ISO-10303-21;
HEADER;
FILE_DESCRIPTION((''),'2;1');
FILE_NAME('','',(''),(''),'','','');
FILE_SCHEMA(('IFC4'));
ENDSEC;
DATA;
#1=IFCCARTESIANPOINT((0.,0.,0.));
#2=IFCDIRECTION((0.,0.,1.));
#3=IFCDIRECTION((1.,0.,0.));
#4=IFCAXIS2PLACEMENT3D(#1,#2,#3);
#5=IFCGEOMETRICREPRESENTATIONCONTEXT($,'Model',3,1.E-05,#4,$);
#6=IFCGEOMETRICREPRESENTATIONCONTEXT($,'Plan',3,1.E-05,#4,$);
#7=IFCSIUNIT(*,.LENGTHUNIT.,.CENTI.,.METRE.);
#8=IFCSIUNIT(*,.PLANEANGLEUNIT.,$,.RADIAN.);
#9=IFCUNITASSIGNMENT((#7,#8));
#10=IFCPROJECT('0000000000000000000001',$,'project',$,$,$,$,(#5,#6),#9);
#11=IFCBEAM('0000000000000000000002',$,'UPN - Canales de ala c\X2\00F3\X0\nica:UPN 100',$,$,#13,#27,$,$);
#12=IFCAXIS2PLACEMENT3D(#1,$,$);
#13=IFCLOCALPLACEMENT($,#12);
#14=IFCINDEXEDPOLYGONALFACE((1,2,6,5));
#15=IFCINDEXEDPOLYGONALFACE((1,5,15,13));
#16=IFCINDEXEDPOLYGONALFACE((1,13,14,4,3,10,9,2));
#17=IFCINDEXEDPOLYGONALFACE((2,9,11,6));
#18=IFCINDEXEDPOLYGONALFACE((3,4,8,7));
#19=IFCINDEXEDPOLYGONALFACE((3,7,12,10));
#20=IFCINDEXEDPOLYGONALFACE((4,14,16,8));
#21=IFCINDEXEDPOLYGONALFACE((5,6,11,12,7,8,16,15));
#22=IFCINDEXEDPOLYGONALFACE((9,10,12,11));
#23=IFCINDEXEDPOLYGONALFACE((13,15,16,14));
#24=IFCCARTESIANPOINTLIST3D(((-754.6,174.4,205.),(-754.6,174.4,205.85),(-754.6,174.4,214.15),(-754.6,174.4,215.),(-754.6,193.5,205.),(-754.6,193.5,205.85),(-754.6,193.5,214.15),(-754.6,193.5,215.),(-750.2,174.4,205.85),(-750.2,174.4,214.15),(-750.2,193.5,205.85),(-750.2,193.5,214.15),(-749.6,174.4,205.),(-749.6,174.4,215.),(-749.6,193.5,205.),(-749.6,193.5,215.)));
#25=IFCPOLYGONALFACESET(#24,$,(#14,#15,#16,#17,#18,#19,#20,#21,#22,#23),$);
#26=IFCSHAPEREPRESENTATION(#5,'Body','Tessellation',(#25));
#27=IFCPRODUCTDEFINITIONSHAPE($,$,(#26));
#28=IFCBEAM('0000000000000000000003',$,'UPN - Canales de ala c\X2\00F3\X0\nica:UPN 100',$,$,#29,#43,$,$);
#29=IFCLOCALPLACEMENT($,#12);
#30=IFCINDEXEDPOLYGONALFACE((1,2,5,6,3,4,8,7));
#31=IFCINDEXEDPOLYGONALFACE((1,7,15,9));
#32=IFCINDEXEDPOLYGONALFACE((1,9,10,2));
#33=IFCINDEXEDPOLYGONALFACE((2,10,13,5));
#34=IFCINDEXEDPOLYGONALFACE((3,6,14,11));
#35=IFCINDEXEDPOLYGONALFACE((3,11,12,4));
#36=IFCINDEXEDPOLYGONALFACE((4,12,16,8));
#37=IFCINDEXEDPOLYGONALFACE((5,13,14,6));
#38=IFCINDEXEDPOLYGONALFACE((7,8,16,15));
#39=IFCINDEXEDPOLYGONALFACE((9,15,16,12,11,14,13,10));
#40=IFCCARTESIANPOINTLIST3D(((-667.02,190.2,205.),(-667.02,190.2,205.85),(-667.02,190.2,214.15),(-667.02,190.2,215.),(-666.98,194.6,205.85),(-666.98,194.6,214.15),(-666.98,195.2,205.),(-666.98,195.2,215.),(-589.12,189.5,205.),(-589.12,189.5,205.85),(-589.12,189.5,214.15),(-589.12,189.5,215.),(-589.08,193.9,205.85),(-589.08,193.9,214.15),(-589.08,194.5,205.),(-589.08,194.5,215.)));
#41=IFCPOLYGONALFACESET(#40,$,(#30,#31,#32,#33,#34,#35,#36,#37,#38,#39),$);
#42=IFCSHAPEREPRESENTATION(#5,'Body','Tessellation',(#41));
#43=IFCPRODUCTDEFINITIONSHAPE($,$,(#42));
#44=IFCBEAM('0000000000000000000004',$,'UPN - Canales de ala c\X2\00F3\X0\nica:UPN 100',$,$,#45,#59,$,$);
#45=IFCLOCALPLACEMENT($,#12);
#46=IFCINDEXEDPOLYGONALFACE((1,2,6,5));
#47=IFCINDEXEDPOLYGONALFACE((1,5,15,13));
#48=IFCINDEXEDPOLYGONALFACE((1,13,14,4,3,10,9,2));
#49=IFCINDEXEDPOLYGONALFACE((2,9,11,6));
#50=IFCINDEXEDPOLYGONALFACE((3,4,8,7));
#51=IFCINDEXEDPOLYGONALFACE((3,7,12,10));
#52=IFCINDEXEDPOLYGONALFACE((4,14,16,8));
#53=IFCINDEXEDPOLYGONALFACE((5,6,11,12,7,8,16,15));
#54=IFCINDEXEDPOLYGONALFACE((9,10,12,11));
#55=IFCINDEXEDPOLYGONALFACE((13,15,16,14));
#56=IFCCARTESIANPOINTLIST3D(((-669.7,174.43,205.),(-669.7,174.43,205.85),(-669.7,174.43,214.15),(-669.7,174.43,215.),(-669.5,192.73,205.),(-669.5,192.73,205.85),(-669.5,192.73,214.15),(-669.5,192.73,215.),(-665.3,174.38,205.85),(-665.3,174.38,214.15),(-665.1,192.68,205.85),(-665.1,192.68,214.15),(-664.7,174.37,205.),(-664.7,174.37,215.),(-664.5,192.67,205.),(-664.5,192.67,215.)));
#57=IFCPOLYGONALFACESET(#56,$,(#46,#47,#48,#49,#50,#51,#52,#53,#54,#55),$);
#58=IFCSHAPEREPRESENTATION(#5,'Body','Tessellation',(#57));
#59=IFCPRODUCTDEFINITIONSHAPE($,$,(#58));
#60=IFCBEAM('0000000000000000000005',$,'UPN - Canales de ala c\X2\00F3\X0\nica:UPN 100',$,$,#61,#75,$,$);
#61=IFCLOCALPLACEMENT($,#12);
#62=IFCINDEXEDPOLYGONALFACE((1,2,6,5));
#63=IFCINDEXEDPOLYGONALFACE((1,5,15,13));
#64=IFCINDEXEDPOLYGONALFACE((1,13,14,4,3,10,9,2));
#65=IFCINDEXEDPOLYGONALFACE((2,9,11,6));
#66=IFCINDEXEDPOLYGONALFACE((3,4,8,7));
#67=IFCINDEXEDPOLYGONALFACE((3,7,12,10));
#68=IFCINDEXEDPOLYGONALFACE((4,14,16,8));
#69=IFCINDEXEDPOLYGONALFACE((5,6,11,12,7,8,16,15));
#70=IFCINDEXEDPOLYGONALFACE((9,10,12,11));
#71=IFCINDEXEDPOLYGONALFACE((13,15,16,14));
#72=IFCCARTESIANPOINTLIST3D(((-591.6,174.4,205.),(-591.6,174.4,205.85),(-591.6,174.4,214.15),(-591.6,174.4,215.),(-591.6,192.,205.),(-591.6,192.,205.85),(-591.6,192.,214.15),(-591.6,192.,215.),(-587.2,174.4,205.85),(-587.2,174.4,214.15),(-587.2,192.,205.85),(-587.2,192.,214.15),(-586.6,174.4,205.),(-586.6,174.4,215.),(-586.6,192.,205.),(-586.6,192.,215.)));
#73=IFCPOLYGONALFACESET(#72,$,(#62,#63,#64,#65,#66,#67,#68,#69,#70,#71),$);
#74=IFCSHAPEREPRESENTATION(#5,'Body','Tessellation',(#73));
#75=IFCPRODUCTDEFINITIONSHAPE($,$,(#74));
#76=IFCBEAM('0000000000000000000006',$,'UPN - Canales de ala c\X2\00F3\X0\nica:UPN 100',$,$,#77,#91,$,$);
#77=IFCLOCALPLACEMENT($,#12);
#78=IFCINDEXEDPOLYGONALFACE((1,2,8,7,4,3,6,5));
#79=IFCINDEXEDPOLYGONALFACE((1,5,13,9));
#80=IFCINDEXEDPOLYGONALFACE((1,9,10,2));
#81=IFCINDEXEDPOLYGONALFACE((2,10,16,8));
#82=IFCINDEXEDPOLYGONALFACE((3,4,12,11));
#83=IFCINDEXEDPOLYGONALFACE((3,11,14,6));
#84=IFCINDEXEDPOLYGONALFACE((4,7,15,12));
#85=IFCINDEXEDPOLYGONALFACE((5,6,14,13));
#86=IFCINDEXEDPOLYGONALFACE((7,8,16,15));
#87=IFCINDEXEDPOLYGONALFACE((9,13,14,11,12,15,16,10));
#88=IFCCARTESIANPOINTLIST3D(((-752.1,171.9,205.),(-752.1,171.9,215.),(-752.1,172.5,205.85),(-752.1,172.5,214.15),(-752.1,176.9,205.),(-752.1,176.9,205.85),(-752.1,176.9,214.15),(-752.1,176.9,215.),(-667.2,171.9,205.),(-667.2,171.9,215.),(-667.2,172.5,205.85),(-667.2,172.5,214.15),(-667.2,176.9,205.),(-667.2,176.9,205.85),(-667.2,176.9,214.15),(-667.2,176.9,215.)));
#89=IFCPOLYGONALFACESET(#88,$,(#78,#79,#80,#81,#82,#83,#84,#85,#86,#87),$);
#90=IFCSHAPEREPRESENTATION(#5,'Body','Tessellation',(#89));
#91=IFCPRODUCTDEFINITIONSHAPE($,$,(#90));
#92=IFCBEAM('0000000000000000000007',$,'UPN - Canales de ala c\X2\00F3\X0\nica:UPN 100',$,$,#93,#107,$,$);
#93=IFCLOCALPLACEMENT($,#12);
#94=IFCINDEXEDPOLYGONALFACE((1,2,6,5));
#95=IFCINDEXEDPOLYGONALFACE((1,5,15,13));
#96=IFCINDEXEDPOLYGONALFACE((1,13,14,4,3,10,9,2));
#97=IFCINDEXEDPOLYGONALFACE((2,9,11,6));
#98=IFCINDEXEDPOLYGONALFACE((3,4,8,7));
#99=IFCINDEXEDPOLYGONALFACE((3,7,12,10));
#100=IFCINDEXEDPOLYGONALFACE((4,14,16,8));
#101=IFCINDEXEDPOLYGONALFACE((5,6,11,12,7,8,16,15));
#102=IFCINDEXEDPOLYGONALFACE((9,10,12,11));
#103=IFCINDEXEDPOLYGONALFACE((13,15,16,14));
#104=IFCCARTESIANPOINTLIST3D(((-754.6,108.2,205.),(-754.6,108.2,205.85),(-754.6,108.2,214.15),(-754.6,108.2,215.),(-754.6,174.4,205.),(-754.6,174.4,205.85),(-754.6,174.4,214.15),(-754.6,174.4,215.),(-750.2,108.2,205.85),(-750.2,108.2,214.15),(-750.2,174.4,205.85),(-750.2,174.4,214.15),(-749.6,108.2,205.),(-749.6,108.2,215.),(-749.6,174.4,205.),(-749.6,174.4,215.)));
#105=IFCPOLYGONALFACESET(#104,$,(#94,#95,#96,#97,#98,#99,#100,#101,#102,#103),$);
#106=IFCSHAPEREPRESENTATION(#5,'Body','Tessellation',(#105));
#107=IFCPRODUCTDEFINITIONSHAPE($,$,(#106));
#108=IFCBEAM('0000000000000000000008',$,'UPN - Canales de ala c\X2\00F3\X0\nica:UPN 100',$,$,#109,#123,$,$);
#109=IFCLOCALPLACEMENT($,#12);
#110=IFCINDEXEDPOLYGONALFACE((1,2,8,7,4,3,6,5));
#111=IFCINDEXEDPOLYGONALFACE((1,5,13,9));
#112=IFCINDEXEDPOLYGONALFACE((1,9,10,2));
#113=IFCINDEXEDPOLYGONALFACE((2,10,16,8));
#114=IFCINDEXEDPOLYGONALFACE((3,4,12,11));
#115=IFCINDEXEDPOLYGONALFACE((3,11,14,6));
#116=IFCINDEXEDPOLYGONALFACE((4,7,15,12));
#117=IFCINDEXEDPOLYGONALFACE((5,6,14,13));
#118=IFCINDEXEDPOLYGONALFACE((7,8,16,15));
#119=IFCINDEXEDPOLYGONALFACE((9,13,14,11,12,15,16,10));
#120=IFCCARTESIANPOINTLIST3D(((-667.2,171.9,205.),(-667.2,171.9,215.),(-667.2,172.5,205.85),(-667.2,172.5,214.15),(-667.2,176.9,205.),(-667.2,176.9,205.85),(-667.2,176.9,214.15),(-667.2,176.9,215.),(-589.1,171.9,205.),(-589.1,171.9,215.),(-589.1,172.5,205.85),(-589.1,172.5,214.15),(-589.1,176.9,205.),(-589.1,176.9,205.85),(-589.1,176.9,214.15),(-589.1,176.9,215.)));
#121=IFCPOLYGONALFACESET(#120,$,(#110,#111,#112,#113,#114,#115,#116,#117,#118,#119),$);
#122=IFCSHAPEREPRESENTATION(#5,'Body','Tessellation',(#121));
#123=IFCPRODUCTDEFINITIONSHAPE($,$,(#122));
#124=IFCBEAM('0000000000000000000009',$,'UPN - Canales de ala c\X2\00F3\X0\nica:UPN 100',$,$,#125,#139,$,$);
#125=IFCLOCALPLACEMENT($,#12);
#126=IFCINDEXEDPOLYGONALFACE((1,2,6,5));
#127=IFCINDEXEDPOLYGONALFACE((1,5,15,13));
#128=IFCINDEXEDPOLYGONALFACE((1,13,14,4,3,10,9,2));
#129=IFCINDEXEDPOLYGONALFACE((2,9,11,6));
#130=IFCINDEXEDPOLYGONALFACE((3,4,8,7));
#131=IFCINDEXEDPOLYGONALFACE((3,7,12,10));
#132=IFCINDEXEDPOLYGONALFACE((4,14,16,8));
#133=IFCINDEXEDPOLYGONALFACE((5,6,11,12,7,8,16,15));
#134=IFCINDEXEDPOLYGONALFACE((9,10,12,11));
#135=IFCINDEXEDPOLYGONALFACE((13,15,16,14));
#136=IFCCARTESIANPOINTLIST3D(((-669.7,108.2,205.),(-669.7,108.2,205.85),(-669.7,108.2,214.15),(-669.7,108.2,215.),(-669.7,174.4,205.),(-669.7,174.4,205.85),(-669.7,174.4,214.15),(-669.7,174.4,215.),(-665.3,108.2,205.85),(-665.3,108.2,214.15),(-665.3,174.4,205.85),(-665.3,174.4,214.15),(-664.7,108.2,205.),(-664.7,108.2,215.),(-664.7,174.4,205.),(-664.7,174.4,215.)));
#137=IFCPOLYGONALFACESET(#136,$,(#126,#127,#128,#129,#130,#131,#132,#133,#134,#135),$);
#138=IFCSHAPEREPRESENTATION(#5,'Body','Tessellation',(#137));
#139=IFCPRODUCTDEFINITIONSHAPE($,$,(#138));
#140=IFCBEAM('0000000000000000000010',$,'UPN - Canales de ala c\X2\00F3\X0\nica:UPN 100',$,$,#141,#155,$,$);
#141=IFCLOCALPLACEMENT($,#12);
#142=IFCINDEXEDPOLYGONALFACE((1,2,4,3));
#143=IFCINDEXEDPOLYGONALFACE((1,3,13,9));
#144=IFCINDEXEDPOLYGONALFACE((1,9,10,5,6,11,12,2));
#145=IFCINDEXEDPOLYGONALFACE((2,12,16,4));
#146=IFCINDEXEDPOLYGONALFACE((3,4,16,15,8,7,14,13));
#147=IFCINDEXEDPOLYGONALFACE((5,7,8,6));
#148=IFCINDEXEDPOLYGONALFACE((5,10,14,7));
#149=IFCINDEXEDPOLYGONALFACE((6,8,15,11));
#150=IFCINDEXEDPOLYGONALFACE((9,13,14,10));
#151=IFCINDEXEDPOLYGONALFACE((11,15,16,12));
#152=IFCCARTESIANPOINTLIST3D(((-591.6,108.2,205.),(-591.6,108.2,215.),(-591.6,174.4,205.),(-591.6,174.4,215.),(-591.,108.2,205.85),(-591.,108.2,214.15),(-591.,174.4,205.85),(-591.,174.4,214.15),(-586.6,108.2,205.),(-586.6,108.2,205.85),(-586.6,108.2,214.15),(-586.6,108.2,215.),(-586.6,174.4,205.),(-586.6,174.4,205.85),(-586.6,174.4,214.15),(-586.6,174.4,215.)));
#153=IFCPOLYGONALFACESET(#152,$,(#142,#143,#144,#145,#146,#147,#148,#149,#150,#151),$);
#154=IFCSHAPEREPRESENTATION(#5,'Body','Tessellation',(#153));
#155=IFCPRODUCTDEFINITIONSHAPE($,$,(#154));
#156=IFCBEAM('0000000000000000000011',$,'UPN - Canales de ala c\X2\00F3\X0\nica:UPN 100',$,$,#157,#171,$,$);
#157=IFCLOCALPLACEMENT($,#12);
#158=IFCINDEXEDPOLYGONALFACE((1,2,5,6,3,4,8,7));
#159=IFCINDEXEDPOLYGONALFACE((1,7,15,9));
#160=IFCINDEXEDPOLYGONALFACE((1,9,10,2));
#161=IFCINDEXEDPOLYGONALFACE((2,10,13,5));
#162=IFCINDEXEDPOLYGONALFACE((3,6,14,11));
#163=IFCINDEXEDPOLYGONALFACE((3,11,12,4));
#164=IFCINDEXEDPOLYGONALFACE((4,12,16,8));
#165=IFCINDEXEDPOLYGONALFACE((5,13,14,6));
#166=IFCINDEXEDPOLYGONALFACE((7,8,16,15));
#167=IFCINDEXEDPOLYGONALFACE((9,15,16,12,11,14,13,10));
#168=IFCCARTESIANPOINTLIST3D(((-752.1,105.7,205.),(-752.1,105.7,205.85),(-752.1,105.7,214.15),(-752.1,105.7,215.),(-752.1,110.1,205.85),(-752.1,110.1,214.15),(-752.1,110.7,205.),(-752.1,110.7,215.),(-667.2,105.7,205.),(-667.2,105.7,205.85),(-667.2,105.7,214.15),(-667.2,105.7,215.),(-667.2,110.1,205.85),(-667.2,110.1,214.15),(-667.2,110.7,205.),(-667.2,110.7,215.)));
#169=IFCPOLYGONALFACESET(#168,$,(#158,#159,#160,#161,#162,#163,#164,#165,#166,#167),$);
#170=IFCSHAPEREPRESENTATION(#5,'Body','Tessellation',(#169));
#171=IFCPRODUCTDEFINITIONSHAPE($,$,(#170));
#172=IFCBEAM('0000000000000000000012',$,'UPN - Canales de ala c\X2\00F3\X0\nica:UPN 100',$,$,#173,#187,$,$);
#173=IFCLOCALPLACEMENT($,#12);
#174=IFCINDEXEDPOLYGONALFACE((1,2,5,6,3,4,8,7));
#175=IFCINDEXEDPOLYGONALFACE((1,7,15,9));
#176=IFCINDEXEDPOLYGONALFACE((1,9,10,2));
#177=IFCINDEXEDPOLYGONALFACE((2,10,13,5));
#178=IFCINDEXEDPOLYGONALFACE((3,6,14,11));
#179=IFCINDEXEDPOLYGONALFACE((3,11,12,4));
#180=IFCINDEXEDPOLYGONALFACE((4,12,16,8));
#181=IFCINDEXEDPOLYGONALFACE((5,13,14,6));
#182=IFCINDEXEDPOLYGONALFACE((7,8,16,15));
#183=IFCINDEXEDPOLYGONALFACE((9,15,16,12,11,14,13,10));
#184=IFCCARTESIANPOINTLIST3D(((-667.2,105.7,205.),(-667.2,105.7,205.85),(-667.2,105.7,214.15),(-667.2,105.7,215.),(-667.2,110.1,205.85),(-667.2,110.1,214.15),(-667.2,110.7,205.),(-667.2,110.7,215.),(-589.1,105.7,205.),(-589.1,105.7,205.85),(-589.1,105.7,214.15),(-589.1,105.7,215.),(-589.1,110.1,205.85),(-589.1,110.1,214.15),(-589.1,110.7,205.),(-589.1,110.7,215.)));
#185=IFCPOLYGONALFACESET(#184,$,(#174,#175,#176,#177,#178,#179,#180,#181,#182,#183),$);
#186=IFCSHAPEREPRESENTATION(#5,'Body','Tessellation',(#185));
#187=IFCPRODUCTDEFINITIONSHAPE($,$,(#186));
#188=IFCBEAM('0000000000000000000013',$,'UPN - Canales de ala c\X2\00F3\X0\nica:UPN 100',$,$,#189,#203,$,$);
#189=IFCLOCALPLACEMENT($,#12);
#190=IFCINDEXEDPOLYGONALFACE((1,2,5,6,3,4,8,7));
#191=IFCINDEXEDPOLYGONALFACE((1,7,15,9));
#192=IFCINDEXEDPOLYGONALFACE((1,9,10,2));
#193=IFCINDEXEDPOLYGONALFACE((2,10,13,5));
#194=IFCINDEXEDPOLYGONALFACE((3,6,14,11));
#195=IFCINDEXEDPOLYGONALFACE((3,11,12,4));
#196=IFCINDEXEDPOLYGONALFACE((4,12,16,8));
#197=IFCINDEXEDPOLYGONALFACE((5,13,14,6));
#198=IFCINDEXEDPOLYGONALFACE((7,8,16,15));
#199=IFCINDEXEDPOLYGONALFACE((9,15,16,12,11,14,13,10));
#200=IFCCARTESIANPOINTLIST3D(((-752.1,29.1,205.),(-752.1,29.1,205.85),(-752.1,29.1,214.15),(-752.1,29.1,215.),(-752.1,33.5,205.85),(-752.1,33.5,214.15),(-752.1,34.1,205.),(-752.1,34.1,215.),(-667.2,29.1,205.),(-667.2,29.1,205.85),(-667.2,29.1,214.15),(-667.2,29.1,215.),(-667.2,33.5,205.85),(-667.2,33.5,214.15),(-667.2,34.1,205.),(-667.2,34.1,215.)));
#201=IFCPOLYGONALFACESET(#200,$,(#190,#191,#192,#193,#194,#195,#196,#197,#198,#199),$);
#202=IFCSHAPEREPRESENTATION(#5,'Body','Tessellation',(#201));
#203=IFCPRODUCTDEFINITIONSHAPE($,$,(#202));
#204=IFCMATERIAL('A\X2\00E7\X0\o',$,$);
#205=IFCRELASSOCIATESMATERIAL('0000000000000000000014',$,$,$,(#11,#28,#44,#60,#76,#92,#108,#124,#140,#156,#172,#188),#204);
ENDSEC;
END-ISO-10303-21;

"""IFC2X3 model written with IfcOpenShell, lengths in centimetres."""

from ifc_helpers import new_model, si_unit, frame, frame_2d, origin_with_axes, origin_2d_with_axis, place, context, project, u_section, extrude, material, element, save


model = new_model("IFC2X3")

# Units and contexts
model_context = context("Model", 3, precision=1e-05, world=origin_with_axes())
plan_context = context("Plan", 3, precision=1e-05, world=origin_with_axes())
ifc_project = project(units=[si_unit("LENGTHUNIT", "METRE", prefix="CENTI"), si_unit("PLANEANGLEUNIT", "RADIAN")], contexts=[model_context, plan_context])

# Shared definitions
ifc_material = material(Name="Aço")

# Beams
beam_1_placement = place(None, frame((-752.1, 174.4, 210.0), z_axis=(0.0, 1.0, 0.0), x_axis=(-1.0, 0.0, 0.0)))
element("IfcBeam", 1, at=beam_1_placement, material=ifc_material, Name="UPN - Canales de ala cónica:UPN 100", context=model_context, shape_type="SweptSolid", body=[
    extrude(u_section(Depth=10.0, FlangeWidth=5.0, WebThickness=0.6, FlangeThickness=0.85, FilletRadius=0.0, EdgeRadius=0.0, FlangeSlope=0.0, CentreOfGravityInX=0.0, at=origin_2d_with_axis()), origin_with_axes(), (0.0, 0.0, 1.0), 19.1),
])
beam_2_placement = place(None, frame((-589.1, 192.0, 210.0), z_axis=(-0.99996, 0.008985, 0.0), x_axis=(-0.008985, -0.99996, 0.0)))
element("IfcBeam", 2, at=beam_2_placement, material=ifc_material, Name="UPN - Canales de ala cónica:UPN 100", context=model_context, shape_type="SweptSolid", body=[
    extrude(u_section(Depth=10.0, FlangeWidth=5.0, WebThickness=0.6, FlangeThickness=0.85, FilletRadius=0.0, EdgeRadius=0.0, FlangeSlope=0.0, CentreOfGravityInX=0.0, at=frame_2d((0.0, 0.0), x_axis=(1.0, 0.0))), origin_with_axes(), (0.0, 0.0, 1.0), 77.9),
])
beam_3_placement = place(None, frame((-667.2, 174.4, 210.0), z_axis=(0.010929, 0.99994, 0.0), x_axis=(-0.99994, 0.010929, 0.0)))
element("IfcBeam", 3, at=beam_3_placement, material=ifc_material, Name="UPN - Canales de ala cónica:UPN 100", context=model_context, shape_type="SweptSolid", body=[
    extrude(u_section(Depth=10.0, FlangeWidth=5.0, WebThickness=0.6, FlangeThickness=0.85, FilletRadius=0.0, EdgeRadius=0.0, FlangeSlope=0.0, CentreOfGravityInX=0.0, at=frame_2d((0.0, 0.0), x_axis=(1.0, 0.0))), origin_with_axes(), (0.0, 0.0, 1.0), 18.3),
])
beam_4_placement = place(None, frame((-589.1, 174.4, 210.0), z_axis=(0.0, 1.0, 0.0), x_axis=(-1.0, 0.0, 0.0)))
element("IfcBeam", 4, at=beam_4_placement, material=ifc_material, Name="UPN - Canales de ala cónica:UPN 100", context=model_context, shape_type="SweptSolid", body=[
    extrude(u_section(Depth=10.0, FlangeWidth=5.0, WebThickness=0.6, FlangeThickness=0.85, FilletRadius=0.0, EdgeRadius=0.0, FlangeSlope=0.0, CentreOfGravityInX=0.0, at=origin_2d_with_axis()), origin_with_axes(), (0.0, 0.0, 1.0), 17.6),
])
beam_5_placement = place(None, frame((-667.2, 174.4, 210.0), z_axis=(-1.0, 0.0, 0.0), x_axis=(0.0, 1.0, 0.0)))
element("IfcBeam", 5, at=beam_5_placement, material=ifc_material, Name="UPN - Canales de ala cónica:UPN 100", context=model_context, shape_type="SweptSolid", body=[
    extrude(u_section(Depth=10.0, FlangeWidth=5.0, WebThickness=0.6, FlangeThickness=0.85, FilletRadius=0.0, EdgeRadius=0.0, FlangeSlope=0.0, CentreOfGravityInX=0.0, at=origin_2d_with_axis()), origin_with_axes(), (0.0, 0.0, 1.0), 84.9),
])
beam_6_placement = place(None, frame((-752.1, 108.2, 210.0), z_axis=(0.0, 1.0, 0.0), x_axis=(-1.0, 0.0, 0.0)))
element("IfcBeam", 6, at=beam_6_placement, material=ifc_material, Name="UPN - Canales de ala cónica:UPN 100", context=model_context, shape_type="SweptSolid", body=[
    extrude(u_section(Depth=10.0, FlangeWidth=5.0, WebThickness=0.6, FlangeThickness=0.85, FilletRadius=0.0, EdgeRadius=0.0, FlangeSlope=0.0, CentreOfGravityInX=0.0, at=origin_2d_with_axis()), origin_with_axes(), (0.0, 0.0, 1.0), 66.2),
])
beam_7_placement = place(None, frame((-589.1, 174.4, 210.0), z_axis=(-1.0, 0.0, 0.0), x_axis=(0.0, 1.0, 0.0)))
element("IfcBeam", 7, at=beam_7_placement, material=ifc_material, Name="UPN - Canales de ala cónica:UPN 100", context=model_context, shape_type="SweptSolid", body=[
    extrude(u_section(Depth=10.0, FlangeWidth=5.0, WebThickness=0.6, FlangeThickness=0.85, FilletRadius=0.0, EdgeRadius=0.0, FlangeSlope=0.0, CentreOfGravityInX=0.0, at=origin_2d_with_axis()), origin_with_axes(), (0.0, 0.0, 1.0), 78.1),
])
for number, where, z_axis, x_axis, name in (
    (8, (-667.2, 108.2, 210.0), (0.0, 1.0, 0.0), (-1.0, 0.0, 0.0), "UPN - Canales de ala cónica:UPN 100"),
    (9, (-589.1, 108.2, 210.0), (0.0, 1.0, 0.0), (1.0, 0.0, 0.0), "UPN - Canales de ala cónica:UPN 100"),
):
    element("IfcBeam", number, at=place(None, frame(where, z_axis=z_axis, x_axis=x_axis)), material=ifc_material, Name=name, context=model_context, shape_type="SweptSolid", body=[
        extrude(u_section(Depth=10.0, FlangeWidth=5.0, WebThickness=0.6, FlangeThickness=0.85, FilletRadius=0.0, EdgeRadius=0.0, FlangeSlope=0.0, CentreOfGravityInX=0.0, at=origin_2d_with_axis()), origin_with_axes(), (0.0, 0.0, 1.0), 66.2),
    ])
beam_8_placement = place(None, frame((-667.2, 108.2, 210.0), z_axis=(-1.0, 0.0, 0.0), x_axis=(0.0, -1.0, 0.0)))
element("IfcBeam", 10, at=beam_8_placement, material=ifc_material, Name="UPN - Canales de ala cónica:UPN 100", context=model_context, shape_type="SweptSolid", body=[
    extrude(u_section(Depth=10.0, FlangeWidth=5.0, WebThickness=0.6, FlangeThickness=0.85, FilletRadius=0.0, EdgeRadius=0.0, FlangeSlope=0.0, CentreOfGravityInX=0.0, at=origin_2d_with_axis()), origin_with_axes(), (0.0, 0.0, 1.0), 84.9),
])
beam_9_placement = place(None, frame((-589.1, 108.2, 210.0), z_axis=(-1.0, 0.0, 0.0), x_axis=(0.0, -1.0, 0.0)))
element("IfcBeam", 11, at=beam_9_placement, material=ifc_material, Name="UPN - Canales de ala cónica:UPN 100", context=model_context, shape_type="SweptSolid", body=[
    extrude(u_section(Depth=10.0, FlangeWidth=5.0, WebThickness=0.6, FlangeThickness=0.85, FilletRadius=0.0, EdgeRadius=0.0, FlangeSlope=0.0, CentreOfGravityInX=0.0, at=origin_2d_with_axis()), origin_with_axes(), (0.0, 0.0, 1.0), 78.1),
])
beam_10_placement = place(None, frame((-667.2, 31.6, 210.0), z_axis=(-1.0, 0.0, 0.0), x_axis=(0.0, -1.0, 0.0)))
element("IfcBeam", 12, at=beam_10_placement, material=ifc_material, Name="UPN - Canales de ala cónica:UPN 100", context=model_context, shape_type="SweptSolid", body=[
    extrude(u_section(Depth=10.0, FlangeWidth=5.0, WebThickness=0.6, FlangeThickness=0.85, FilletRadius=0.0, EdgeRadius=0.0, FlangeSlope=0.0, CentreOfGravityInX=0.0, at=frame_2d((0.0, 0.0), x_axis=(1.0, 0.0))), origin_with_axes(), (0.0, 0.0, 1.0), 84.9),
])

save(model, "model.ifc")
